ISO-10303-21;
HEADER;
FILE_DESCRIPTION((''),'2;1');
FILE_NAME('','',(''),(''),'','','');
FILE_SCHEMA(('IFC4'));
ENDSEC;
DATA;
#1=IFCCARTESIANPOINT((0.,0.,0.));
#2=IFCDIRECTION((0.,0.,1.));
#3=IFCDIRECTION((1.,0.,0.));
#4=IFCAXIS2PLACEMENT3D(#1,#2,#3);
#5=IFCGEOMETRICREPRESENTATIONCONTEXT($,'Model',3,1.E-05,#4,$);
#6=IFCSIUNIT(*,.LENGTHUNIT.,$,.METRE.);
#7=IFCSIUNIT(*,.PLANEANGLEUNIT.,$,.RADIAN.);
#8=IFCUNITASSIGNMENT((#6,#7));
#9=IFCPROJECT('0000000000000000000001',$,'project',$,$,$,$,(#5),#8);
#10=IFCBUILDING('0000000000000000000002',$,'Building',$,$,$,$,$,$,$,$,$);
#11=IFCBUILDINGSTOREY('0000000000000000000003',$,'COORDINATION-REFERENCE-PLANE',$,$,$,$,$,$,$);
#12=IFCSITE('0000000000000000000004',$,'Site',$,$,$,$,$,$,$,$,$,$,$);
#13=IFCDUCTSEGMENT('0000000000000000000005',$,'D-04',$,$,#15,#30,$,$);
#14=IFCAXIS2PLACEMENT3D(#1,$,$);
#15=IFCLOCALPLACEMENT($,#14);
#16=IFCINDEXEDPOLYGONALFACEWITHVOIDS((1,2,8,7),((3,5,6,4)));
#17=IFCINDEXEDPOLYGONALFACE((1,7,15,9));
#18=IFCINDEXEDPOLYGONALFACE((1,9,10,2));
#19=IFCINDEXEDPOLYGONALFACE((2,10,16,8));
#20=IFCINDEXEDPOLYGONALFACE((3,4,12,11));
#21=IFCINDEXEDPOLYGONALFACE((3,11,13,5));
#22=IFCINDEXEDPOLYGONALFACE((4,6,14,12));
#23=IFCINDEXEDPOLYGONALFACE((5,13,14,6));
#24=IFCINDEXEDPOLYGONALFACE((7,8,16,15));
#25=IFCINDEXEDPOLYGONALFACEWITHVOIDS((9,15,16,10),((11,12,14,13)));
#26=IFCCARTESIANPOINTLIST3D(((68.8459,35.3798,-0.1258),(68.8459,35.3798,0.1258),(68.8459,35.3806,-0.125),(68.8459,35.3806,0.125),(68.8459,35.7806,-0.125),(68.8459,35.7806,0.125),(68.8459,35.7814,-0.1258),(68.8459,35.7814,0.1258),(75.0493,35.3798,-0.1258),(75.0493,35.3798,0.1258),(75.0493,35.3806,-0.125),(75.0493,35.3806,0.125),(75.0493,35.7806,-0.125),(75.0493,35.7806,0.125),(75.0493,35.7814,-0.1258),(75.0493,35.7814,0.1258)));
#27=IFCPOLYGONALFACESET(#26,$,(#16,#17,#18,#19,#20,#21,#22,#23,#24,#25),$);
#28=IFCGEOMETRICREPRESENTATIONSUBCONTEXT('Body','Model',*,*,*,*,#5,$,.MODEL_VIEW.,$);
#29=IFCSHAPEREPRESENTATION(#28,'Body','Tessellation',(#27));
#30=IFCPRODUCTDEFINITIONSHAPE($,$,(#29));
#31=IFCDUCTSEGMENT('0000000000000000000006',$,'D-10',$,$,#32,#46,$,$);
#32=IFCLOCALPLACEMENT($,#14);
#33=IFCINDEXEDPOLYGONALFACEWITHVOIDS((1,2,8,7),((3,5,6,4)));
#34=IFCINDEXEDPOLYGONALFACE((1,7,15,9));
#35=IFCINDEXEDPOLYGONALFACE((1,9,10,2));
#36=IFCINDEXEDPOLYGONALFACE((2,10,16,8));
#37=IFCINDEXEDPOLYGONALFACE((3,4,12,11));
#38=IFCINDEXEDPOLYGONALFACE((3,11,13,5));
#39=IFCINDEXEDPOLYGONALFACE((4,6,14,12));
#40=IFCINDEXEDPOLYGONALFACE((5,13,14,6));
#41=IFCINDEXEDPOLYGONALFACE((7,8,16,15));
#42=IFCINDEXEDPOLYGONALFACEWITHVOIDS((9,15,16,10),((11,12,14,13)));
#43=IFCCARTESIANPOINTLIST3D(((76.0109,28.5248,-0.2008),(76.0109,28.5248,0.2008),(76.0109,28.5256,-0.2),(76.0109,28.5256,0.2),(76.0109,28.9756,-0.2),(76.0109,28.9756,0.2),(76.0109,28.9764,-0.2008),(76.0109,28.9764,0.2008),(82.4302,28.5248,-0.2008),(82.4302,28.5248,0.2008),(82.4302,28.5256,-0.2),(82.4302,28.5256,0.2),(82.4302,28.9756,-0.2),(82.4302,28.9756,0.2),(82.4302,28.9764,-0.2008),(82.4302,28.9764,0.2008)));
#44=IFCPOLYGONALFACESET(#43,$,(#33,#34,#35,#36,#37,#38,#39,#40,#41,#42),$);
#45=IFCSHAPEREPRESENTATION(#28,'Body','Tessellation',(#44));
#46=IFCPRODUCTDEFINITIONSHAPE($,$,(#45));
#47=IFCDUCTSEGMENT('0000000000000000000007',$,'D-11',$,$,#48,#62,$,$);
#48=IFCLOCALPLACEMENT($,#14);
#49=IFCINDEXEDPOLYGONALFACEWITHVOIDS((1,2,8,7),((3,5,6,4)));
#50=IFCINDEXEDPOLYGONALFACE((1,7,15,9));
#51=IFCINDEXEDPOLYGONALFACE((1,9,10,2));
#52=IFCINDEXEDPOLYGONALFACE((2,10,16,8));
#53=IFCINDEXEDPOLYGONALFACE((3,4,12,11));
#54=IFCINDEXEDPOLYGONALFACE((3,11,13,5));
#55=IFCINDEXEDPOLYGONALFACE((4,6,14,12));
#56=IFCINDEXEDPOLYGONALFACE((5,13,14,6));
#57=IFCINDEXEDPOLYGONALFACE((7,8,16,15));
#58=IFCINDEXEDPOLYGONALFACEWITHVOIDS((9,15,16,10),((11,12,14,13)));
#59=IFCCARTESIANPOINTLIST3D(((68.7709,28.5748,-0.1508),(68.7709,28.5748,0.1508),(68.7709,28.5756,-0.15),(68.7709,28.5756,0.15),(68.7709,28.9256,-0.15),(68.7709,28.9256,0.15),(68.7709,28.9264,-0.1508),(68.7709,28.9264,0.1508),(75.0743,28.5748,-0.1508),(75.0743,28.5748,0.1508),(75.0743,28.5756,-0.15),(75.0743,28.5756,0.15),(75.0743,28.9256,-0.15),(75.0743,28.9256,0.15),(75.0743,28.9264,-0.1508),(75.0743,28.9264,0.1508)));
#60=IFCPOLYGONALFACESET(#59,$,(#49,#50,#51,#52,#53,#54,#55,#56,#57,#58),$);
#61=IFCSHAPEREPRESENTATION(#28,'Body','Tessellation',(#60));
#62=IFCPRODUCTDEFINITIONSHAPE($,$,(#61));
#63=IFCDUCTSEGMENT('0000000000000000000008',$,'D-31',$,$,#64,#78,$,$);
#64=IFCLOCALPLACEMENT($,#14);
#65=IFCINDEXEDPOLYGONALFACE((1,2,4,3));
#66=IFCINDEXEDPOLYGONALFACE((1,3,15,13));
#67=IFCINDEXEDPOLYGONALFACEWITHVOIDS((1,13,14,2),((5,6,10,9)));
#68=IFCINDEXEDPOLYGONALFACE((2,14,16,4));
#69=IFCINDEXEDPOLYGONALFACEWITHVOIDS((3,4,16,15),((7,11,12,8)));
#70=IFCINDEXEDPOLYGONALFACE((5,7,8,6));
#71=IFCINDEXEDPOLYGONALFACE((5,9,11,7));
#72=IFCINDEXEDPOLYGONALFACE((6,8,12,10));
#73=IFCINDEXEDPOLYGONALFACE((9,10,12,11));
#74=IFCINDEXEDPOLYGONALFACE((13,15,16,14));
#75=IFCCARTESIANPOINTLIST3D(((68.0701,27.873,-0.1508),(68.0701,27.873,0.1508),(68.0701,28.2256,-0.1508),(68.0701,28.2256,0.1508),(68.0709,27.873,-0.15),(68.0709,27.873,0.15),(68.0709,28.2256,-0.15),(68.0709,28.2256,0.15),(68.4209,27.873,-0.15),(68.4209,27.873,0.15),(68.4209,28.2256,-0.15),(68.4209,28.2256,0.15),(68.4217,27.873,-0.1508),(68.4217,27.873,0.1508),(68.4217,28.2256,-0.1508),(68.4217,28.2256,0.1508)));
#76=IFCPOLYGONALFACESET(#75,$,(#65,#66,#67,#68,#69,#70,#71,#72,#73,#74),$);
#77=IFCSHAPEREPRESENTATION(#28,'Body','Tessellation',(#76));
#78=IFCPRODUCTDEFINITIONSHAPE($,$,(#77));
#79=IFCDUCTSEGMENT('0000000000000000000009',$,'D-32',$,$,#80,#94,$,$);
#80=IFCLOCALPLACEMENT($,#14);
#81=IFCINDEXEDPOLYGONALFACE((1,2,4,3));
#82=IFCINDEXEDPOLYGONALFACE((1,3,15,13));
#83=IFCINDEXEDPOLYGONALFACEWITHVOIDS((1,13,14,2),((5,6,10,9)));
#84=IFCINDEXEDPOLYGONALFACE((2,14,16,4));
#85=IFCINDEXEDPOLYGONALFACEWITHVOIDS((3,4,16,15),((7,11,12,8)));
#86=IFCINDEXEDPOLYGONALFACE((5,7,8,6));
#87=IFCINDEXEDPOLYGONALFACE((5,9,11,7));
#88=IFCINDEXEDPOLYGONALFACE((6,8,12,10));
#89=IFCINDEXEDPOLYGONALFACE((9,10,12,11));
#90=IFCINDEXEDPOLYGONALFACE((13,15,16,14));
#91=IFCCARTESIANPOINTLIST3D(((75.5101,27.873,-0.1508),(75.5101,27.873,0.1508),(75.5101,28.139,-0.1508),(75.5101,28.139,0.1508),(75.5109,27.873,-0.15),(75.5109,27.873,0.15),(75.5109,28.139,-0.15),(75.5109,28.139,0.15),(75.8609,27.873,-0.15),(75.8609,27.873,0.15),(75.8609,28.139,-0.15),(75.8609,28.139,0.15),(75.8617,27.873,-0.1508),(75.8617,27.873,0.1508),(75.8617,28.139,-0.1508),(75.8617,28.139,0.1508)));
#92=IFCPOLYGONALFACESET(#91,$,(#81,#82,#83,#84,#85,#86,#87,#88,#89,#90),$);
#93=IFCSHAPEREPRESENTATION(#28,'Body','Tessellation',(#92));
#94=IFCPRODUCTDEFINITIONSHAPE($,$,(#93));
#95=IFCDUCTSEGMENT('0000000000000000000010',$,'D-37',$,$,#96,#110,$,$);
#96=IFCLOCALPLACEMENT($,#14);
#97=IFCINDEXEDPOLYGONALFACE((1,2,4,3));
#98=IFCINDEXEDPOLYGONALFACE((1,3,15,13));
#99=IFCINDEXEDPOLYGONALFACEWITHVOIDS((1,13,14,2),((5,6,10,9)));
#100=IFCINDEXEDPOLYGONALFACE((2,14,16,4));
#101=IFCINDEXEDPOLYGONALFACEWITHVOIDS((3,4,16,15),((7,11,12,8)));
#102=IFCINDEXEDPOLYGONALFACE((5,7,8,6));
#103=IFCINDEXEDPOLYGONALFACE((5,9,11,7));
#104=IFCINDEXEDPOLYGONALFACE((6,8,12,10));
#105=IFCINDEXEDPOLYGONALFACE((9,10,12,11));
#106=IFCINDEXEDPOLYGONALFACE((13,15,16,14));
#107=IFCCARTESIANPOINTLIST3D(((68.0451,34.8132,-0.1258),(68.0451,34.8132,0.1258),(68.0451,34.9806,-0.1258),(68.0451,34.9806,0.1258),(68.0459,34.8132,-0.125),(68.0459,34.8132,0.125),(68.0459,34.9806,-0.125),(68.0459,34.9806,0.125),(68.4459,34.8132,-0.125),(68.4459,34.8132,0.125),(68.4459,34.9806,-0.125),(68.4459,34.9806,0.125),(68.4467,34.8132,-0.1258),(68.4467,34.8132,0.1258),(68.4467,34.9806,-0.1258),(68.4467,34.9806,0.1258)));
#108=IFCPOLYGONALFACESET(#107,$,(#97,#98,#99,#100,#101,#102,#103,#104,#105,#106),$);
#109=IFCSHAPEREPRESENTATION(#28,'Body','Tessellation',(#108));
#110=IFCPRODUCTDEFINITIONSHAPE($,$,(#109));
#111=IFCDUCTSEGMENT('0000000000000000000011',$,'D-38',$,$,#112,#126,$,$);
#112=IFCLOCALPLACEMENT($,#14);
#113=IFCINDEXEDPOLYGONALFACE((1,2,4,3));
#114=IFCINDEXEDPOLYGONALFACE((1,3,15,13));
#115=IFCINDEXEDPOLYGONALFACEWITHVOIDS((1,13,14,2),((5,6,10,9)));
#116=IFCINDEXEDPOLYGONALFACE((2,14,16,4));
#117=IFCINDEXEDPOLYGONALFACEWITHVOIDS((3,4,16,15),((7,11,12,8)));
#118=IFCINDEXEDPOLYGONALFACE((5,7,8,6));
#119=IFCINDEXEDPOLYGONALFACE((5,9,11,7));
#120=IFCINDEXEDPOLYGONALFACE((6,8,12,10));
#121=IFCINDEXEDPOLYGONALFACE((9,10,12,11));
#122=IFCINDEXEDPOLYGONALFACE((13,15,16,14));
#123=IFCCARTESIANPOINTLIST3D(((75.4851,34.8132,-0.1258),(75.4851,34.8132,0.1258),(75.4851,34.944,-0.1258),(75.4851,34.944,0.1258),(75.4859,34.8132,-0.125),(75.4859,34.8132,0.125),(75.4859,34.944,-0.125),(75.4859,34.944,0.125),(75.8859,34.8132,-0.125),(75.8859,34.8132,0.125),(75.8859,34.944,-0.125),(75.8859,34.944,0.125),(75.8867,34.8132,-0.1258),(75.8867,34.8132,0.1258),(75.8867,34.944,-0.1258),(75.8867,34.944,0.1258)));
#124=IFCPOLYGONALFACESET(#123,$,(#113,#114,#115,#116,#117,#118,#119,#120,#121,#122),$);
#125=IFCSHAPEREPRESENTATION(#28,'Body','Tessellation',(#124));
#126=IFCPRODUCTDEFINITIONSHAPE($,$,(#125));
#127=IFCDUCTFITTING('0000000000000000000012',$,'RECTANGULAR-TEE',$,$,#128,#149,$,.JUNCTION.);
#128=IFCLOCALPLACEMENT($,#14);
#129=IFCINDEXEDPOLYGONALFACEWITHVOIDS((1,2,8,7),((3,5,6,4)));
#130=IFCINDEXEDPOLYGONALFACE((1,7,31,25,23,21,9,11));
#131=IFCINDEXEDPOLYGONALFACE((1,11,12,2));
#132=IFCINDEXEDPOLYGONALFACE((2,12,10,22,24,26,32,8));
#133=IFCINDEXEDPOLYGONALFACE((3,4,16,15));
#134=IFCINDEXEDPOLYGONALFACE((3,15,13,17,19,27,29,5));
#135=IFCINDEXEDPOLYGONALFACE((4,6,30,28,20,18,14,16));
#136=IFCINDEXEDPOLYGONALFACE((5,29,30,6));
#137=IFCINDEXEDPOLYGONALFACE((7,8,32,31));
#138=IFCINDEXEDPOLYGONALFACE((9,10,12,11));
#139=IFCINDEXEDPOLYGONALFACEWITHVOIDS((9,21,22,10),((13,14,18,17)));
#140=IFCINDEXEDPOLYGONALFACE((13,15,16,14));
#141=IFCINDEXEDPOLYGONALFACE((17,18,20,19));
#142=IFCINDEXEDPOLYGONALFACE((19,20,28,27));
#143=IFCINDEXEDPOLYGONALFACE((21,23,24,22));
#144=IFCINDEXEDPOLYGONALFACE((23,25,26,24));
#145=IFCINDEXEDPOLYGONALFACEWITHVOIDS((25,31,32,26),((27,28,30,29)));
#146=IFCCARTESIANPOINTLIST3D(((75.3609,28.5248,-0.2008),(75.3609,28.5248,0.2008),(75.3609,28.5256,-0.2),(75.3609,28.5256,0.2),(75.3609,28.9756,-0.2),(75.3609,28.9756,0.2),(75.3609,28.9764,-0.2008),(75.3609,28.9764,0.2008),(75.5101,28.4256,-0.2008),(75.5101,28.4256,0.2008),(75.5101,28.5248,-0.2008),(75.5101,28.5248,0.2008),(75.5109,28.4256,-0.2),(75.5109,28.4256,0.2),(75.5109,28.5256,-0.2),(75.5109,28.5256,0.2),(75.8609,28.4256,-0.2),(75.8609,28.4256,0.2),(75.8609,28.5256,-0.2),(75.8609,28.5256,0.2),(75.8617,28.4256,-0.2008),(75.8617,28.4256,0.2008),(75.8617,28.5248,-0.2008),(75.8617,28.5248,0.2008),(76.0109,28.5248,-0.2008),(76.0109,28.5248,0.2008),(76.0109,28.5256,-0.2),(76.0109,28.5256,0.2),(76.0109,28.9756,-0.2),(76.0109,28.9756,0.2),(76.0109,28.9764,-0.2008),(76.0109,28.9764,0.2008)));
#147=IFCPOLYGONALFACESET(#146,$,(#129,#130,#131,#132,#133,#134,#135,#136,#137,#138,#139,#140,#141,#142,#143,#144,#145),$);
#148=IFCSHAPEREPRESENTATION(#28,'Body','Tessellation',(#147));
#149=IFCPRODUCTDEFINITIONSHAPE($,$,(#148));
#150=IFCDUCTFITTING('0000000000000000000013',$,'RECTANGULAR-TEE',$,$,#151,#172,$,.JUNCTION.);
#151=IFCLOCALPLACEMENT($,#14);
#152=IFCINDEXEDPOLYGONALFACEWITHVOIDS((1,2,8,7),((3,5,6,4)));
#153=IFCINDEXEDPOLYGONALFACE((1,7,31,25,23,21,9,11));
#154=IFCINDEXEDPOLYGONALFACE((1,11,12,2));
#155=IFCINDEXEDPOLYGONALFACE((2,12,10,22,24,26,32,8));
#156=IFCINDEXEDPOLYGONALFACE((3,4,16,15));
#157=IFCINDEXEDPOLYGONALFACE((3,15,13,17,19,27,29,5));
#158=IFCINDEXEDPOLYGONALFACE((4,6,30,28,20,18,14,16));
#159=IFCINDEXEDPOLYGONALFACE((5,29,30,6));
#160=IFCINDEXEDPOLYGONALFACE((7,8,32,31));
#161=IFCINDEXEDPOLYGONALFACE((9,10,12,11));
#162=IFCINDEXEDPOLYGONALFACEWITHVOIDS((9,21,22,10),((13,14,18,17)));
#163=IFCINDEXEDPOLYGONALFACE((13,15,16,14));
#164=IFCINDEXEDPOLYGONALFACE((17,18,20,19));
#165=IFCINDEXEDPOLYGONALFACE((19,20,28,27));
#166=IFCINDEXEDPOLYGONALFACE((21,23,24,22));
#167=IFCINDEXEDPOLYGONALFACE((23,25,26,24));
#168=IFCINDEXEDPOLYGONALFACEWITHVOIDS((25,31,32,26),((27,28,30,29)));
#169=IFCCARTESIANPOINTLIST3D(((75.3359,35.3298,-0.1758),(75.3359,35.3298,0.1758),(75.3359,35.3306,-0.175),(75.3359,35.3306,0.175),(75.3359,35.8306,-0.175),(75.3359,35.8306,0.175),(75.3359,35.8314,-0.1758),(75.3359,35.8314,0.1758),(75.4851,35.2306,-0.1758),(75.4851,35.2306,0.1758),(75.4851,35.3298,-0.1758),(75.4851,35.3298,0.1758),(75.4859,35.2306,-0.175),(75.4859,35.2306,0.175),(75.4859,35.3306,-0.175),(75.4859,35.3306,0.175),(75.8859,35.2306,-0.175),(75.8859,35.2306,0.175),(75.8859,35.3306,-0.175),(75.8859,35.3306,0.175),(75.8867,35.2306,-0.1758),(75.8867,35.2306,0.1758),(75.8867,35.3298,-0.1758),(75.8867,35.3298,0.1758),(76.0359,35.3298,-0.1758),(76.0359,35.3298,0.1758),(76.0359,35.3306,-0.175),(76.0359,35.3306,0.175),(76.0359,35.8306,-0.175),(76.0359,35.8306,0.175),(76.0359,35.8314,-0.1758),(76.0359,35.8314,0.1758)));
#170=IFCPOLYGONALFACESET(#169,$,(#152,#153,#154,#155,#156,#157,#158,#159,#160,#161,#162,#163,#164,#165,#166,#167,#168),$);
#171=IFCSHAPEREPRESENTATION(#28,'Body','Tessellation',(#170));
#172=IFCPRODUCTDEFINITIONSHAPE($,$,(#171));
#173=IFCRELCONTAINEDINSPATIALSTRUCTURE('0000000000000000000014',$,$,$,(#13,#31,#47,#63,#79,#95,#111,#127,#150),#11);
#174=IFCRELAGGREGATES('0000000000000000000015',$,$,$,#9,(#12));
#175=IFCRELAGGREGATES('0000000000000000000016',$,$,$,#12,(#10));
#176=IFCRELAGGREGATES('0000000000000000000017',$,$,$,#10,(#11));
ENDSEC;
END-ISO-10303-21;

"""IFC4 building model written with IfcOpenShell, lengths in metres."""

from ifc_helpers import new_model, si_unit, frame, origin, origin_with_axes, place, context, subcontext, project, spatial, rectangle, hollow_rectangle, extrude, boolean, element, save


model = new_model("IFC4")

# Units and contexts
model_context = context("Model", 3, precision=1e-05, world=origin_with_axes())
body_context_1 = subcontext(model_context, "Body", "Model", "MODEL_VIEW")
ifc_project = project(units=[si_unit("LENGTHUNIT", "METRE"), si_unit("PLANEANGLEUNIT", "RADIAN")], contexts=[model_context])

# Site, building, storey
site = spatial("IfcSite", under=ifc_project, Name="Site")
building = spatial("IfcBuilding", under=site, Name="Building")
storey = spatial("IfcBuildingStorey", under=building, Name="COORDINATION-REFERENCE-PLANE")

# Duct segments
duct_segment_1_placement = place(None, frame((68.8459, 35.5806, 0.0), z_axis=(1.0, 0.0, 0.0), x_axis=(0.0, 1.0, 0.0)))
element("IfcDuctSegment", 1, at=duct_segment_1_placement, inside=storey, Name="D-04", context=body_context_1, shape_type="SweptSolid", body=[
    extrude(hollow_rectangle(XDim=0.4016, YDim=0.2516, WallThickness=0.0008), origin(), (0.0, 0.0, 1.0), 6.2034),
])
duct_segment_2_placement = place(None, frame((76.0109, 28.7506, 0.0), z_axis=(1.0, 0.0, 0.0), x_axis=(0.0, 1.0, 0.0)))
element("IfcDuctSegment", 2, at=duct_segment_2_placement, inside=storey, Name="D-10", context=body_context_1, shape_type="SweptSolid", body=[
    extrude(hollow_rectangle(XDim=0.4516, YDim=0.4016, WallThickness=0.0008), origin(), (0.0, 0.0, 1.0), 6.4193),
])
duct_segment_3_placement = place(None, frame((68.7709, 28.7506, 0.0), z_axis=(1.0, 0.0, 0.0), x_axis=(0.0, 1.0, 0.0)))
element("IfcDuctSegment", 3, at=duct_segment_3_placement, inside=storey, Name="D-11", context=body_context_1, shape_type="SweptSolid", body=[
    extrude(hollow_rectangle(XDim=0.3516, YDim=0.3016, WallThickness=0.0008), origin(), (0.0, 0.0, 1.0), 6.3034),
])
duct_segment_4_placement = place(None, frame((68.2459, 27.873, 0.0), z_axis=(0.0, 1.0, 0.0), x_axis=(1.0, 0.0, 0.0)))
element("IfcDuctSegment", 4, at=duct_segment_4_placement, inside=storey, Name="D-31", context=body_context_1, shape_type="SweptSolid", body=[
    extrude(hollow_rectangle(XDim=0.3516, YDim=0.3016, WallThickness=0.0008), origin(), (0.0, 0.0, 1.0), 0.3526),
])
duct_segment_5_placement = place(None, frame((75.6859, 27.873, 0.0), z_axis=(0.0, 1.0, 0.0), x_axis=(1.0, 0.0, 0.0)))
element("IfcDuctSegment", 5, at=duct_segment_5_placement, inside=storey, Name="D-32", context=body_context_1, shape_type="SweptSolid", body=[
    extrude(hollow_rectangle(XDim=0.3516, YDim=0.3016, WallThickness=0.0008), origin(), (0.0, 0.0, 1.0), 0.266),
])
duct_segment_6_placement = place(None, frame((68.2459, 34.8132, 0.0), z_axis=(0.0, 1.0, 0.0), x_axis=(1.0, 0.0, 0.0)))
element("IfcDuctSegment", 6, at=duct_segment_6_placement, inside=storey, Name="D-37", context=body_context_1, shape_type="SweptSolid", body=[
    extrude(hollow_rectangle(XDim=0.4016, YDim=0.2516, WallThickness=0.0008), origin(), (0.0, 0.0, 1.0), 0.1673),
])
duct_segment_7_placement = place(None, frame((75.6859, 34.8132, 0.0), z_axis=(0.0, 1.0, 0.0), x_axis=(1.0, 0.0, 0.0)))
element("IfcDuctSegment", 7, at=duct_segment_7_placement, inside=storey, Name="D-38", context=body_context_1, shape_type="SweptSolid", body=[
    extrude(hollow_rectangle(XDim=0.4016, YDim=0.2516, WallThickness=0.0008), origin(), (0.0, 0.0, 1.0), 0.1307),
])

# Duct fittings
duct_fitting_1_placement = place(None, frame((75.6859, 28.7506, 0.0), z_axis=(-1.0, 0.0, 0.0), x_axis=(0.0, -1.0, 0.0)))
solid_1 = boolean("UNION", extrude(rectangle(XDim=0.45, YDim=0.4), frame((0.0, 0.0, -0.325), z_axis=(0.0, 0.0, 1.0), x_axis=(1.0, 0.0, 0.0)), (0.0, 0.0, 1.0), 0.65), extrude(rectangle(XDim=0.35, YDim=0.4), frame((0.0, 0.0, 0.0), z_axis=(1.0, 0.0, 0.0), x_axis=(0.0, 0.0, -1.0)), (0.0, 0.0, 1.0), 0.325))
element("IfcDuctFitting", 8, at=duct_fitting_1_placement, inside=storey, Name="RECTANGULAR-TEE", PredefinedType="JUNCTION", context=body_context_1, shape_type="CSG", body=[
    boolean("DIFFERENCE", boolean("UNION", extrude(rectangle(XDim=0.4516, YDim=0.4016), frame((0.0, 0.0, -0.325), z_axis=(0.0, 0.0, 1.0), x_axis=(1.0, 0.0, 0.0)), (0.0, 0.0, 1.0), 0.65), extrude(rectangle(XDim=0.3516, YDim=0.4016), frame((0.0, 0.0, 0.0), z_axis=(1.0, 0.0, 0.0), x_axis=(0.0, 0.0, -1.0)), (0.0, 0.0, 1.0), 0.325)), solid_1),
])
duct_fitting_2_placement = place(None, frame((75.6859, 35.5806, 0.0), z_axis=(-1.0, 0.0, 0.0), x_axis=(0.0, -1.0, 0.0)))
solid_2 = boolean("UNION", extrude(rectangle(XDim=0.5, YDim=0.35), frame((0.0, 0.0, -0.35), z_axis=(0.0, 0.0, 1.0), x_axis=(1.0, 0.0, 0.0)), (0.0, 0.0, 1.0), 0.7), extrude(rectangle(XDim=0.4, YDim=0.35), frame((0.0, 0.0, 0.0), z_axis=(1.0, 0.0, 0.0), x_axis=(0.0, 0.0, -1.0)), (0.0, 0.0, 1.0), 0.35))
element("IfcDuctFitting", 9, at=duct_fitting_2_placement, inside=storey, Name="RECTANGULAR-TEE", PredefinedType="JUNCTION", context=body_context_1, shape_type="CSG", body=[
    boolean("DIFFERENCE", boolean("UNION", extrude(rectangle(XDim=0.5016, YDim=0.3516), frame((0.0, 0.0, -0.35), z_axis=(0.0, 0.0, 1.0), x_axis=(1.0, 0.0, 0.0)), (0.0, 0.0, 1.0), 0.7), extrude(rectangle(XDim=0.4016, YDim=0.3516), frame((0.0, 0.0, 0.0), z_axis=(1.0, 0.0, 0.0), x_axis=(0.0, 0.0, -1.0)), (0.0, 0.0, 1.0), 0.35)), solid_2),
])

save(model, "model.ifc")
